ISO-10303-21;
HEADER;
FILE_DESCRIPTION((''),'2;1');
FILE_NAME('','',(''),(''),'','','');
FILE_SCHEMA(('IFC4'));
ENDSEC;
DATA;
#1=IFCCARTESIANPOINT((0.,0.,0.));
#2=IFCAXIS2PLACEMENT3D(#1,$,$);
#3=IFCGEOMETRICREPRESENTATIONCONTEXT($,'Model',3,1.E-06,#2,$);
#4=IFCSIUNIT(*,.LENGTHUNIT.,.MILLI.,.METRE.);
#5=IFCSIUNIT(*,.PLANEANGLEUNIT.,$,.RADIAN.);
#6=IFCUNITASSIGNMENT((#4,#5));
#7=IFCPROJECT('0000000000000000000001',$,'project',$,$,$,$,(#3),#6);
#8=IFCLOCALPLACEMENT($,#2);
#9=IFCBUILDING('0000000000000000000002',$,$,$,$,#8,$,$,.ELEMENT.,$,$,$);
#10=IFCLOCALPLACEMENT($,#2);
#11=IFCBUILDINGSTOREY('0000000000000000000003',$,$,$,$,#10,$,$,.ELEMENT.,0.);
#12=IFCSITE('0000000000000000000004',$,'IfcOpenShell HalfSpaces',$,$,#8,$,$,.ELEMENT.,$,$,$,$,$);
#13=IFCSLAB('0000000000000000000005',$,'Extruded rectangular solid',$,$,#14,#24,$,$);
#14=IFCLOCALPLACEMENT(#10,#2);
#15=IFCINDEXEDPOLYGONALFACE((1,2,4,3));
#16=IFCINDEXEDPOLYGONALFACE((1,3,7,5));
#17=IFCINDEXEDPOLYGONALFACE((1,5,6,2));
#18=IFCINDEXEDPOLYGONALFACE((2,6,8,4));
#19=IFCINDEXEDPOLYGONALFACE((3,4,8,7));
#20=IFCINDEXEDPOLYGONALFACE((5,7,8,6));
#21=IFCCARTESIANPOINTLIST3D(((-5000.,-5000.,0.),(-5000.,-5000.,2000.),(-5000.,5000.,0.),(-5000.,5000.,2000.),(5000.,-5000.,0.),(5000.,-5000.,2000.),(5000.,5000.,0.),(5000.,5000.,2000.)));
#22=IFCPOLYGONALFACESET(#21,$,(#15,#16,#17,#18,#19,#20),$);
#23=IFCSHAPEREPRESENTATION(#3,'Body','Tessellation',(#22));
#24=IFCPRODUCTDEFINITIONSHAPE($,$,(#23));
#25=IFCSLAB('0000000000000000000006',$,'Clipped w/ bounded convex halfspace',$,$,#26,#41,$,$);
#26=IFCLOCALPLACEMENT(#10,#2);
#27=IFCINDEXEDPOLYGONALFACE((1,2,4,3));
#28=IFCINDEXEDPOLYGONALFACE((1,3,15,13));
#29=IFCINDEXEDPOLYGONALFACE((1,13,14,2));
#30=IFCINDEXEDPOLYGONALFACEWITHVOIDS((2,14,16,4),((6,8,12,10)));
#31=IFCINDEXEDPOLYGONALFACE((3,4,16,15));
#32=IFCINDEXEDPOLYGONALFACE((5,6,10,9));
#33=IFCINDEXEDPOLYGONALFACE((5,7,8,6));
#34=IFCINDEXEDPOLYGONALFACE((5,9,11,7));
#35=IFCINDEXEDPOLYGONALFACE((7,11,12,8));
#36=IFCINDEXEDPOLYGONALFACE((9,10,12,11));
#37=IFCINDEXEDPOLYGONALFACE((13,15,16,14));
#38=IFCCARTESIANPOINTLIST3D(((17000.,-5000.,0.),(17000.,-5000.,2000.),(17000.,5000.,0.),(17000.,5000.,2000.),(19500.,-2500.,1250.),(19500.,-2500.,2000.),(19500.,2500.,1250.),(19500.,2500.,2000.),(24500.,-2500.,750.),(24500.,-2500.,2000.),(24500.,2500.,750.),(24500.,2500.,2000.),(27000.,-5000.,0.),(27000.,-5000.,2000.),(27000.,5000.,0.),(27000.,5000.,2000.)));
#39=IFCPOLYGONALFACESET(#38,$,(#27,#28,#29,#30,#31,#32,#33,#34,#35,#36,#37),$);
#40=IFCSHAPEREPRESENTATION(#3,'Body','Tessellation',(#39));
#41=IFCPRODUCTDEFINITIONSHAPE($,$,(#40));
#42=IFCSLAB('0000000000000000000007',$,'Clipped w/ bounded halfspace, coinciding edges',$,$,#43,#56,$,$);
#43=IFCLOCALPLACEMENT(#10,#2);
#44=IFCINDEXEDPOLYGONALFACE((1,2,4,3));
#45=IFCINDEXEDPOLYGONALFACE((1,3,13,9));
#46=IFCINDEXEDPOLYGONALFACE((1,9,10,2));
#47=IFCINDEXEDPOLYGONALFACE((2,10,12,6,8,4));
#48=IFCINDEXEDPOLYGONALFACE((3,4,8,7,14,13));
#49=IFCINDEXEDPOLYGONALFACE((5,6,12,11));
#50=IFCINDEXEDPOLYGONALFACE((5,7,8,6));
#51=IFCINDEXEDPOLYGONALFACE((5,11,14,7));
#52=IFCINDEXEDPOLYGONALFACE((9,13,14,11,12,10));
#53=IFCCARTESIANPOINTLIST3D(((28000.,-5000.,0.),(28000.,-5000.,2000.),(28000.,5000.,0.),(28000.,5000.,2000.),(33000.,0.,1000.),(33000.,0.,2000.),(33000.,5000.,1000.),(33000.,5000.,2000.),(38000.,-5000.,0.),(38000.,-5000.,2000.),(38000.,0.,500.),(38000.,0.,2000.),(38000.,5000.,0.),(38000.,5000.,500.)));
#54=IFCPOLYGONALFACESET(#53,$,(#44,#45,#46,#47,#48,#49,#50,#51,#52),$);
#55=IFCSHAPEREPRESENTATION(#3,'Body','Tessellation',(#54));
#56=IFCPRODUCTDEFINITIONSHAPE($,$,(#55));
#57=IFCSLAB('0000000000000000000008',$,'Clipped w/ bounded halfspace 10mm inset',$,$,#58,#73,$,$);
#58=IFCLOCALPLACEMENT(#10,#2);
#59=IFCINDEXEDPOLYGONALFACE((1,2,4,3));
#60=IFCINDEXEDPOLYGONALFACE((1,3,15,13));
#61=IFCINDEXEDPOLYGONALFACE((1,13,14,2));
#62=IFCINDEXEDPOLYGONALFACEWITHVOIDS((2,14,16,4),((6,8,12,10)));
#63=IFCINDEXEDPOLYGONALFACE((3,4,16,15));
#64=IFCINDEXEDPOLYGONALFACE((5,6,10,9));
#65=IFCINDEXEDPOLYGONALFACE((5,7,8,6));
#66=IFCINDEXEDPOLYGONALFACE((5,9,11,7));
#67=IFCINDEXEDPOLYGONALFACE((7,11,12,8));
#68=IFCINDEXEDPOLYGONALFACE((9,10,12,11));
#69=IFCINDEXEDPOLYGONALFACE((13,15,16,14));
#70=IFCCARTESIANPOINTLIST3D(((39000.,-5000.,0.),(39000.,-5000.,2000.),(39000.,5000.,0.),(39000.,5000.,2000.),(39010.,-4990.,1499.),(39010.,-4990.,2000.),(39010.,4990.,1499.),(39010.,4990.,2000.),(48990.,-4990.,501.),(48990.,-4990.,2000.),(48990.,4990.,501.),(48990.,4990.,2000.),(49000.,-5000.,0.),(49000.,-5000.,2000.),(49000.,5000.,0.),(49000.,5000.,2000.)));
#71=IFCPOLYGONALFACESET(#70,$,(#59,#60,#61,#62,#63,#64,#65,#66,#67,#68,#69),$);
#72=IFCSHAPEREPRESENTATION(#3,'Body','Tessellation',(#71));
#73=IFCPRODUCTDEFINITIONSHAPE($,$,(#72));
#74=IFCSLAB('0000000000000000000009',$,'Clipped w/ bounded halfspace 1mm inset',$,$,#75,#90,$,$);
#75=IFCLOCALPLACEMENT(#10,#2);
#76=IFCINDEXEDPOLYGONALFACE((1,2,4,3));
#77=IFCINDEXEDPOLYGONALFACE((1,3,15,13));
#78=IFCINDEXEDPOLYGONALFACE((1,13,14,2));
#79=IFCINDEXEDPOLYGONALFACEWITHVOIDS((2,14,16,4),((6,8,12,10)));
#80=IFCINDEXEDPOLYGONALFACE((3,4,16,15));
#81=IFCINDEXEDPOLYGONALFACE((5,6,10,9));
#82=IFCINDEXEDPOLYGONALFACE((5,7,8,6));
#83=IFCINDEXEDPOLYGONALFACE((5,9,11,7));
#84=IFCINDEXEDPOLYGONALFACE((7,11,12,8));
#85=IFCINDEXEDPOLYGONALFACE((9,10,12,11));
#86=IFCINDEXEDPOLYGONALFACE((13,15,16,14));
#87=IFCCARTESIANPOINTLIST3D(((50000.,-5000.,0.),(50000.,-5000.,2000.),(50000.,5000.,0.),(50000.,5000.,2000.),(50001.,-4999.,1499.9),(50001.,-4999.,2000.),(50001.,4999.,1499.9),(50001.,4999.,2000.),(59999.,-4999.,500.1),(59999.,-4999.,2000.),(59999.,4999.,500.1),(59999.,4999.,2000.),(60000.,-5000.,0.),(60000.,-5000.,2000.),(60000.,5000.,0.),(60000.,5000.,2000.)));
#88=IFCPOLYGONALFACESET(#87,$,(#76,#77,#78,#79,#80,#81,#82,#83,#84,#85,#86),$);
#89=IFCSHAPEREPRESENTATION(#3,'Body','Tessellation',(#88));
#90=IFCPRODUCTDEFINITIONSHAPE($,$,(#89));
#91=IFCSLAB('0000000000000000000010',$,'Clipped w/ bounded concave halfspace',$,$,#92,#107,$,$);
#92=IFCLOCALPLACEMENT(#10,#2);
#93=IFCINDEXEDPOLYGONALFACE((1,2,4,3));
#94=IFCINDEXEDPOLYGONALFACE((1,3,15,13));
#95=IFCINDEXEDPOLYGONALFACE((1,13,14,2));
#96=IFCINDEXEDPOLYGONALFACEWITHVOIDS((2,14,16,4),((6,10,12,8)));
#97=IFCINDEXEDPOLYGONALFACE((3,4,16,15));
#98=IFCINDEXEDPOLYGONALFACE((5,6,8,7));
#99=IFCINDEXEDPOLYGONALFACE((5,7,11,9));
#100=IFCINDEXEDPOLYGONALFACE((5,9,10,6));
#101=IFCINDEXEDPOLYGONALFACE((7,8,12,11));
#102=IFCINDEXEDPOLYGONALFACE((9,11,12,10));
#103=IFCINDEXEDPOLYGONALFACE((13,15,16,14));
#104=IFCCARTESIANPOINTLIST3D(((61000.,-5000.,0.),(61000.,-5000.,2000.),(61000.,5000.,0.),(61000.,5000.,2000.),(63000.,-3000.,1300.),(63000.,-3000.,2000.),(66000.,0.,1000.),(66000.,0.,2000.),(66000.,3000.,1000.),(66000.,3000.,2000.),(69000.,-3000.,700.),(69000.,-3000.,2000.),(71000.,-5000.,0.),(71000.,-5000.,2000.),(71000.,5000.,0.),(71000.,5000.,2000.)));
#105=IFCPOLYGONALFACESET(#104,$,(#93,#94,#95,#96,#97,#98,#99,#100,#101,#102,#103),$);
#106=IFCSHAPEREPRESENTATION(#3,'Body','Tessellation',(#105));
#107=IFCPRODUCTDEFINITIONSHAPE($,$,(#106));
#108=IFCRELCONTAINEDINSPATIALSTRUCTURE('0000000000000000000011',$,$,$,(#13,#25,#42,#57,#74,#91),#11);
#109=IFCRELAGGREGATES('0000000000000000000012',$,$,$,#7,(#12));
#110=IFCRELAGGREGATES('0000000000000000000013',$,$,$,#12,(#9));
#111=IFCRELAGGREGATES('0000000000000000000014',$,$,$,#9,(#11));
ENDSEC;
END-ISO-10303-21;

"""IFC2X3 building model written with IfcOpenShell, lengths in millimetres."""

from ifc_helpers import new_model, si_unit, frame, origin, origin_2d_with_axis, place, context, project, spatial, polyline, rectangle, extrude, clip, bounded_halfspace, element, save


model = new_model("IFC2X3")

# Units and contexts
model_context = context("Model", 3, precision=1e-06, world=origin())
ifc_project = project(units=[si_unit("LENGTHUNIT", "METRE", prefix="MILLI"), si_unit("PLANEANGLEUNIT", "RADIAN")], contexts=[model_context])

# Site, building, storey
placement_1 = place(None, origin())
site = spatial("IfcSite", under=ifc_project, at=placement_1, Name="IfcOpenShell HalfSpaces", CompositionType="ELEMENT")
building = spatial("IfcBuilding", under=site, at=placement_1, CompositionType="ELEMENT")
placement_2 = place(None, origin())
storey = spatial("IfcBuildingStorey", under=building, at=placement_2, CompositionType="ELEMENT", Elevation=0.0)

# Slabs
element("IfcSlab", 1, at=placement_2, inside=storey, Name="Extruded rectangular solid", context=model_context, shape_type="SweptSolid", body=[
    extrude(rectangle(XDim=10000.0, YDim=10000.0, at=origin_2d_with_axis()), origin(), (0.0, 0.0, 1.0), 2000.0),
])
slab_1_placement = place(None, frame((22000.0, 0.0, 0.0)))
element("IfcSlab", 2, at=slab_1_placement, inside=storey, Name="Clipped w/ bounded convex halfspace", context=model_context, shape_type="Clipping", body=[
    clip(extrude(rectangle(XDim=10000.0, YDim=10000.0, at=origin_2d_with_axis()), origin(), (0.0, 0.0, 1.0), 2000.0), bounded_halfspace(frame((0.0, 0.0, 1000.0), z_axis=(1.0, 0.0, 10.0)), False, origin(), polyline([(-2500.0, -2500.0), (2500.0, -2500.0), (2500.0, 2500.0), (-2500.0, 2500.0), (-2500.0, -2500.0)]))),
])
slab_2_placement = place(None, frame((33000.0, 0.0, 0.0)))
element("IfcSlab", 3, at=slab_2_placement, inside=storey, Name="Clipped w/ bounded halfspace, coinciding edges", context=model_context, shape_type="Clipping", body=[
    clip(extrude(rectangle(XDim=10000.0, YDim=10000.0, at=origin_2d_with_axis()), origin(), (0.0, 0.0, 1.0), 2000.0), bounded_halfspace(frame((0.0, 0.0, 1000.0), z_axis=(1.0, 0.0, 10.0)), False, origin(), polyline([(0.0, 0.0), (5000.0, 0.0), (5000.0, 5000.0), (0.0, 5000.0), (0.0, 0.0)]))),
])
slab_3_placement = place(None, frame((44000.0, 0.0, 0.0)))
element("IfcSlab", 4, at=slab_3_placement, inside=storey, Name="Clipped w/ bounded halfspace 10mm inset", context=model_context, shape_type="Clipping", body=[
    clip(extrude(rectangle(XDim=10000.0, YDim=10000.0, at=origin_2d_with_axis()), origin(), (0.0, 0.0, 1.0), 2000.0), bounded_halfspace(frame((0.0, 0.0, 1000.0), z_axis=(1.0, 0.0, 10.0)), False, origin(), polyline([(-4990.0, -4990.0), (4990.0, -4990.0), (4990.0, 4990.0), (-4990.0, 4990.0), (-4990.0, -4990.0)]))),
])
slab_4_placement = place(None, frame((55000.0, 0.0, 0.0)))
element("IfcSlab", 5, at=slab_4_placement, inside=storey, Name="Clipped w/ bounded halfspace 1mm inset", context=model_context, shape_type="Clipping", body=[
    clip(extrude(rectangle(XDim=10000.0, YDim=10000.0, at=origin_2d_with_axis()), origin(), (0.0, 0.0, 1.0), 2000.0), bounded_halfspace(frame((0.0, 0.0, 1000.0), z_axis=(1.0, 0.0, 10.0)), False, origin(), polyline([(-4999.0, -4999.0), (4999.0, -4999.0), (4999.0, 4999.0), (-4999.0, 4999.0), (-4999.0, -4999.0)]))),
])
slab_5_placement = place(None, frame((66000.0, 0.0, 0.0)))
element("IfcSlab", 6, at=slab_5_placement, inside=storey, Name="Clipped w/ bounded concave halfspace", context=model_context, shape_type="Clipping", body=[
    clip(extrude(rectangle(XDim=10000.0, YDim=10000.0, at=origin_2d_with_axis()), origin(), (0.0, 0.0, 1.0), 2000.0), bounded_halfspace(frame((0.0, 0.0, 1000.0), z_axis=(1.0, 0.0, 10.0)), False, origin(), polyline([(0.0, 3000.0), (3000.0, -3000.0), (0.0, 0.0), (-3000.0, -3000.0), (0.0, 3000.0)]))),
])

save(model, "model.ifc")
